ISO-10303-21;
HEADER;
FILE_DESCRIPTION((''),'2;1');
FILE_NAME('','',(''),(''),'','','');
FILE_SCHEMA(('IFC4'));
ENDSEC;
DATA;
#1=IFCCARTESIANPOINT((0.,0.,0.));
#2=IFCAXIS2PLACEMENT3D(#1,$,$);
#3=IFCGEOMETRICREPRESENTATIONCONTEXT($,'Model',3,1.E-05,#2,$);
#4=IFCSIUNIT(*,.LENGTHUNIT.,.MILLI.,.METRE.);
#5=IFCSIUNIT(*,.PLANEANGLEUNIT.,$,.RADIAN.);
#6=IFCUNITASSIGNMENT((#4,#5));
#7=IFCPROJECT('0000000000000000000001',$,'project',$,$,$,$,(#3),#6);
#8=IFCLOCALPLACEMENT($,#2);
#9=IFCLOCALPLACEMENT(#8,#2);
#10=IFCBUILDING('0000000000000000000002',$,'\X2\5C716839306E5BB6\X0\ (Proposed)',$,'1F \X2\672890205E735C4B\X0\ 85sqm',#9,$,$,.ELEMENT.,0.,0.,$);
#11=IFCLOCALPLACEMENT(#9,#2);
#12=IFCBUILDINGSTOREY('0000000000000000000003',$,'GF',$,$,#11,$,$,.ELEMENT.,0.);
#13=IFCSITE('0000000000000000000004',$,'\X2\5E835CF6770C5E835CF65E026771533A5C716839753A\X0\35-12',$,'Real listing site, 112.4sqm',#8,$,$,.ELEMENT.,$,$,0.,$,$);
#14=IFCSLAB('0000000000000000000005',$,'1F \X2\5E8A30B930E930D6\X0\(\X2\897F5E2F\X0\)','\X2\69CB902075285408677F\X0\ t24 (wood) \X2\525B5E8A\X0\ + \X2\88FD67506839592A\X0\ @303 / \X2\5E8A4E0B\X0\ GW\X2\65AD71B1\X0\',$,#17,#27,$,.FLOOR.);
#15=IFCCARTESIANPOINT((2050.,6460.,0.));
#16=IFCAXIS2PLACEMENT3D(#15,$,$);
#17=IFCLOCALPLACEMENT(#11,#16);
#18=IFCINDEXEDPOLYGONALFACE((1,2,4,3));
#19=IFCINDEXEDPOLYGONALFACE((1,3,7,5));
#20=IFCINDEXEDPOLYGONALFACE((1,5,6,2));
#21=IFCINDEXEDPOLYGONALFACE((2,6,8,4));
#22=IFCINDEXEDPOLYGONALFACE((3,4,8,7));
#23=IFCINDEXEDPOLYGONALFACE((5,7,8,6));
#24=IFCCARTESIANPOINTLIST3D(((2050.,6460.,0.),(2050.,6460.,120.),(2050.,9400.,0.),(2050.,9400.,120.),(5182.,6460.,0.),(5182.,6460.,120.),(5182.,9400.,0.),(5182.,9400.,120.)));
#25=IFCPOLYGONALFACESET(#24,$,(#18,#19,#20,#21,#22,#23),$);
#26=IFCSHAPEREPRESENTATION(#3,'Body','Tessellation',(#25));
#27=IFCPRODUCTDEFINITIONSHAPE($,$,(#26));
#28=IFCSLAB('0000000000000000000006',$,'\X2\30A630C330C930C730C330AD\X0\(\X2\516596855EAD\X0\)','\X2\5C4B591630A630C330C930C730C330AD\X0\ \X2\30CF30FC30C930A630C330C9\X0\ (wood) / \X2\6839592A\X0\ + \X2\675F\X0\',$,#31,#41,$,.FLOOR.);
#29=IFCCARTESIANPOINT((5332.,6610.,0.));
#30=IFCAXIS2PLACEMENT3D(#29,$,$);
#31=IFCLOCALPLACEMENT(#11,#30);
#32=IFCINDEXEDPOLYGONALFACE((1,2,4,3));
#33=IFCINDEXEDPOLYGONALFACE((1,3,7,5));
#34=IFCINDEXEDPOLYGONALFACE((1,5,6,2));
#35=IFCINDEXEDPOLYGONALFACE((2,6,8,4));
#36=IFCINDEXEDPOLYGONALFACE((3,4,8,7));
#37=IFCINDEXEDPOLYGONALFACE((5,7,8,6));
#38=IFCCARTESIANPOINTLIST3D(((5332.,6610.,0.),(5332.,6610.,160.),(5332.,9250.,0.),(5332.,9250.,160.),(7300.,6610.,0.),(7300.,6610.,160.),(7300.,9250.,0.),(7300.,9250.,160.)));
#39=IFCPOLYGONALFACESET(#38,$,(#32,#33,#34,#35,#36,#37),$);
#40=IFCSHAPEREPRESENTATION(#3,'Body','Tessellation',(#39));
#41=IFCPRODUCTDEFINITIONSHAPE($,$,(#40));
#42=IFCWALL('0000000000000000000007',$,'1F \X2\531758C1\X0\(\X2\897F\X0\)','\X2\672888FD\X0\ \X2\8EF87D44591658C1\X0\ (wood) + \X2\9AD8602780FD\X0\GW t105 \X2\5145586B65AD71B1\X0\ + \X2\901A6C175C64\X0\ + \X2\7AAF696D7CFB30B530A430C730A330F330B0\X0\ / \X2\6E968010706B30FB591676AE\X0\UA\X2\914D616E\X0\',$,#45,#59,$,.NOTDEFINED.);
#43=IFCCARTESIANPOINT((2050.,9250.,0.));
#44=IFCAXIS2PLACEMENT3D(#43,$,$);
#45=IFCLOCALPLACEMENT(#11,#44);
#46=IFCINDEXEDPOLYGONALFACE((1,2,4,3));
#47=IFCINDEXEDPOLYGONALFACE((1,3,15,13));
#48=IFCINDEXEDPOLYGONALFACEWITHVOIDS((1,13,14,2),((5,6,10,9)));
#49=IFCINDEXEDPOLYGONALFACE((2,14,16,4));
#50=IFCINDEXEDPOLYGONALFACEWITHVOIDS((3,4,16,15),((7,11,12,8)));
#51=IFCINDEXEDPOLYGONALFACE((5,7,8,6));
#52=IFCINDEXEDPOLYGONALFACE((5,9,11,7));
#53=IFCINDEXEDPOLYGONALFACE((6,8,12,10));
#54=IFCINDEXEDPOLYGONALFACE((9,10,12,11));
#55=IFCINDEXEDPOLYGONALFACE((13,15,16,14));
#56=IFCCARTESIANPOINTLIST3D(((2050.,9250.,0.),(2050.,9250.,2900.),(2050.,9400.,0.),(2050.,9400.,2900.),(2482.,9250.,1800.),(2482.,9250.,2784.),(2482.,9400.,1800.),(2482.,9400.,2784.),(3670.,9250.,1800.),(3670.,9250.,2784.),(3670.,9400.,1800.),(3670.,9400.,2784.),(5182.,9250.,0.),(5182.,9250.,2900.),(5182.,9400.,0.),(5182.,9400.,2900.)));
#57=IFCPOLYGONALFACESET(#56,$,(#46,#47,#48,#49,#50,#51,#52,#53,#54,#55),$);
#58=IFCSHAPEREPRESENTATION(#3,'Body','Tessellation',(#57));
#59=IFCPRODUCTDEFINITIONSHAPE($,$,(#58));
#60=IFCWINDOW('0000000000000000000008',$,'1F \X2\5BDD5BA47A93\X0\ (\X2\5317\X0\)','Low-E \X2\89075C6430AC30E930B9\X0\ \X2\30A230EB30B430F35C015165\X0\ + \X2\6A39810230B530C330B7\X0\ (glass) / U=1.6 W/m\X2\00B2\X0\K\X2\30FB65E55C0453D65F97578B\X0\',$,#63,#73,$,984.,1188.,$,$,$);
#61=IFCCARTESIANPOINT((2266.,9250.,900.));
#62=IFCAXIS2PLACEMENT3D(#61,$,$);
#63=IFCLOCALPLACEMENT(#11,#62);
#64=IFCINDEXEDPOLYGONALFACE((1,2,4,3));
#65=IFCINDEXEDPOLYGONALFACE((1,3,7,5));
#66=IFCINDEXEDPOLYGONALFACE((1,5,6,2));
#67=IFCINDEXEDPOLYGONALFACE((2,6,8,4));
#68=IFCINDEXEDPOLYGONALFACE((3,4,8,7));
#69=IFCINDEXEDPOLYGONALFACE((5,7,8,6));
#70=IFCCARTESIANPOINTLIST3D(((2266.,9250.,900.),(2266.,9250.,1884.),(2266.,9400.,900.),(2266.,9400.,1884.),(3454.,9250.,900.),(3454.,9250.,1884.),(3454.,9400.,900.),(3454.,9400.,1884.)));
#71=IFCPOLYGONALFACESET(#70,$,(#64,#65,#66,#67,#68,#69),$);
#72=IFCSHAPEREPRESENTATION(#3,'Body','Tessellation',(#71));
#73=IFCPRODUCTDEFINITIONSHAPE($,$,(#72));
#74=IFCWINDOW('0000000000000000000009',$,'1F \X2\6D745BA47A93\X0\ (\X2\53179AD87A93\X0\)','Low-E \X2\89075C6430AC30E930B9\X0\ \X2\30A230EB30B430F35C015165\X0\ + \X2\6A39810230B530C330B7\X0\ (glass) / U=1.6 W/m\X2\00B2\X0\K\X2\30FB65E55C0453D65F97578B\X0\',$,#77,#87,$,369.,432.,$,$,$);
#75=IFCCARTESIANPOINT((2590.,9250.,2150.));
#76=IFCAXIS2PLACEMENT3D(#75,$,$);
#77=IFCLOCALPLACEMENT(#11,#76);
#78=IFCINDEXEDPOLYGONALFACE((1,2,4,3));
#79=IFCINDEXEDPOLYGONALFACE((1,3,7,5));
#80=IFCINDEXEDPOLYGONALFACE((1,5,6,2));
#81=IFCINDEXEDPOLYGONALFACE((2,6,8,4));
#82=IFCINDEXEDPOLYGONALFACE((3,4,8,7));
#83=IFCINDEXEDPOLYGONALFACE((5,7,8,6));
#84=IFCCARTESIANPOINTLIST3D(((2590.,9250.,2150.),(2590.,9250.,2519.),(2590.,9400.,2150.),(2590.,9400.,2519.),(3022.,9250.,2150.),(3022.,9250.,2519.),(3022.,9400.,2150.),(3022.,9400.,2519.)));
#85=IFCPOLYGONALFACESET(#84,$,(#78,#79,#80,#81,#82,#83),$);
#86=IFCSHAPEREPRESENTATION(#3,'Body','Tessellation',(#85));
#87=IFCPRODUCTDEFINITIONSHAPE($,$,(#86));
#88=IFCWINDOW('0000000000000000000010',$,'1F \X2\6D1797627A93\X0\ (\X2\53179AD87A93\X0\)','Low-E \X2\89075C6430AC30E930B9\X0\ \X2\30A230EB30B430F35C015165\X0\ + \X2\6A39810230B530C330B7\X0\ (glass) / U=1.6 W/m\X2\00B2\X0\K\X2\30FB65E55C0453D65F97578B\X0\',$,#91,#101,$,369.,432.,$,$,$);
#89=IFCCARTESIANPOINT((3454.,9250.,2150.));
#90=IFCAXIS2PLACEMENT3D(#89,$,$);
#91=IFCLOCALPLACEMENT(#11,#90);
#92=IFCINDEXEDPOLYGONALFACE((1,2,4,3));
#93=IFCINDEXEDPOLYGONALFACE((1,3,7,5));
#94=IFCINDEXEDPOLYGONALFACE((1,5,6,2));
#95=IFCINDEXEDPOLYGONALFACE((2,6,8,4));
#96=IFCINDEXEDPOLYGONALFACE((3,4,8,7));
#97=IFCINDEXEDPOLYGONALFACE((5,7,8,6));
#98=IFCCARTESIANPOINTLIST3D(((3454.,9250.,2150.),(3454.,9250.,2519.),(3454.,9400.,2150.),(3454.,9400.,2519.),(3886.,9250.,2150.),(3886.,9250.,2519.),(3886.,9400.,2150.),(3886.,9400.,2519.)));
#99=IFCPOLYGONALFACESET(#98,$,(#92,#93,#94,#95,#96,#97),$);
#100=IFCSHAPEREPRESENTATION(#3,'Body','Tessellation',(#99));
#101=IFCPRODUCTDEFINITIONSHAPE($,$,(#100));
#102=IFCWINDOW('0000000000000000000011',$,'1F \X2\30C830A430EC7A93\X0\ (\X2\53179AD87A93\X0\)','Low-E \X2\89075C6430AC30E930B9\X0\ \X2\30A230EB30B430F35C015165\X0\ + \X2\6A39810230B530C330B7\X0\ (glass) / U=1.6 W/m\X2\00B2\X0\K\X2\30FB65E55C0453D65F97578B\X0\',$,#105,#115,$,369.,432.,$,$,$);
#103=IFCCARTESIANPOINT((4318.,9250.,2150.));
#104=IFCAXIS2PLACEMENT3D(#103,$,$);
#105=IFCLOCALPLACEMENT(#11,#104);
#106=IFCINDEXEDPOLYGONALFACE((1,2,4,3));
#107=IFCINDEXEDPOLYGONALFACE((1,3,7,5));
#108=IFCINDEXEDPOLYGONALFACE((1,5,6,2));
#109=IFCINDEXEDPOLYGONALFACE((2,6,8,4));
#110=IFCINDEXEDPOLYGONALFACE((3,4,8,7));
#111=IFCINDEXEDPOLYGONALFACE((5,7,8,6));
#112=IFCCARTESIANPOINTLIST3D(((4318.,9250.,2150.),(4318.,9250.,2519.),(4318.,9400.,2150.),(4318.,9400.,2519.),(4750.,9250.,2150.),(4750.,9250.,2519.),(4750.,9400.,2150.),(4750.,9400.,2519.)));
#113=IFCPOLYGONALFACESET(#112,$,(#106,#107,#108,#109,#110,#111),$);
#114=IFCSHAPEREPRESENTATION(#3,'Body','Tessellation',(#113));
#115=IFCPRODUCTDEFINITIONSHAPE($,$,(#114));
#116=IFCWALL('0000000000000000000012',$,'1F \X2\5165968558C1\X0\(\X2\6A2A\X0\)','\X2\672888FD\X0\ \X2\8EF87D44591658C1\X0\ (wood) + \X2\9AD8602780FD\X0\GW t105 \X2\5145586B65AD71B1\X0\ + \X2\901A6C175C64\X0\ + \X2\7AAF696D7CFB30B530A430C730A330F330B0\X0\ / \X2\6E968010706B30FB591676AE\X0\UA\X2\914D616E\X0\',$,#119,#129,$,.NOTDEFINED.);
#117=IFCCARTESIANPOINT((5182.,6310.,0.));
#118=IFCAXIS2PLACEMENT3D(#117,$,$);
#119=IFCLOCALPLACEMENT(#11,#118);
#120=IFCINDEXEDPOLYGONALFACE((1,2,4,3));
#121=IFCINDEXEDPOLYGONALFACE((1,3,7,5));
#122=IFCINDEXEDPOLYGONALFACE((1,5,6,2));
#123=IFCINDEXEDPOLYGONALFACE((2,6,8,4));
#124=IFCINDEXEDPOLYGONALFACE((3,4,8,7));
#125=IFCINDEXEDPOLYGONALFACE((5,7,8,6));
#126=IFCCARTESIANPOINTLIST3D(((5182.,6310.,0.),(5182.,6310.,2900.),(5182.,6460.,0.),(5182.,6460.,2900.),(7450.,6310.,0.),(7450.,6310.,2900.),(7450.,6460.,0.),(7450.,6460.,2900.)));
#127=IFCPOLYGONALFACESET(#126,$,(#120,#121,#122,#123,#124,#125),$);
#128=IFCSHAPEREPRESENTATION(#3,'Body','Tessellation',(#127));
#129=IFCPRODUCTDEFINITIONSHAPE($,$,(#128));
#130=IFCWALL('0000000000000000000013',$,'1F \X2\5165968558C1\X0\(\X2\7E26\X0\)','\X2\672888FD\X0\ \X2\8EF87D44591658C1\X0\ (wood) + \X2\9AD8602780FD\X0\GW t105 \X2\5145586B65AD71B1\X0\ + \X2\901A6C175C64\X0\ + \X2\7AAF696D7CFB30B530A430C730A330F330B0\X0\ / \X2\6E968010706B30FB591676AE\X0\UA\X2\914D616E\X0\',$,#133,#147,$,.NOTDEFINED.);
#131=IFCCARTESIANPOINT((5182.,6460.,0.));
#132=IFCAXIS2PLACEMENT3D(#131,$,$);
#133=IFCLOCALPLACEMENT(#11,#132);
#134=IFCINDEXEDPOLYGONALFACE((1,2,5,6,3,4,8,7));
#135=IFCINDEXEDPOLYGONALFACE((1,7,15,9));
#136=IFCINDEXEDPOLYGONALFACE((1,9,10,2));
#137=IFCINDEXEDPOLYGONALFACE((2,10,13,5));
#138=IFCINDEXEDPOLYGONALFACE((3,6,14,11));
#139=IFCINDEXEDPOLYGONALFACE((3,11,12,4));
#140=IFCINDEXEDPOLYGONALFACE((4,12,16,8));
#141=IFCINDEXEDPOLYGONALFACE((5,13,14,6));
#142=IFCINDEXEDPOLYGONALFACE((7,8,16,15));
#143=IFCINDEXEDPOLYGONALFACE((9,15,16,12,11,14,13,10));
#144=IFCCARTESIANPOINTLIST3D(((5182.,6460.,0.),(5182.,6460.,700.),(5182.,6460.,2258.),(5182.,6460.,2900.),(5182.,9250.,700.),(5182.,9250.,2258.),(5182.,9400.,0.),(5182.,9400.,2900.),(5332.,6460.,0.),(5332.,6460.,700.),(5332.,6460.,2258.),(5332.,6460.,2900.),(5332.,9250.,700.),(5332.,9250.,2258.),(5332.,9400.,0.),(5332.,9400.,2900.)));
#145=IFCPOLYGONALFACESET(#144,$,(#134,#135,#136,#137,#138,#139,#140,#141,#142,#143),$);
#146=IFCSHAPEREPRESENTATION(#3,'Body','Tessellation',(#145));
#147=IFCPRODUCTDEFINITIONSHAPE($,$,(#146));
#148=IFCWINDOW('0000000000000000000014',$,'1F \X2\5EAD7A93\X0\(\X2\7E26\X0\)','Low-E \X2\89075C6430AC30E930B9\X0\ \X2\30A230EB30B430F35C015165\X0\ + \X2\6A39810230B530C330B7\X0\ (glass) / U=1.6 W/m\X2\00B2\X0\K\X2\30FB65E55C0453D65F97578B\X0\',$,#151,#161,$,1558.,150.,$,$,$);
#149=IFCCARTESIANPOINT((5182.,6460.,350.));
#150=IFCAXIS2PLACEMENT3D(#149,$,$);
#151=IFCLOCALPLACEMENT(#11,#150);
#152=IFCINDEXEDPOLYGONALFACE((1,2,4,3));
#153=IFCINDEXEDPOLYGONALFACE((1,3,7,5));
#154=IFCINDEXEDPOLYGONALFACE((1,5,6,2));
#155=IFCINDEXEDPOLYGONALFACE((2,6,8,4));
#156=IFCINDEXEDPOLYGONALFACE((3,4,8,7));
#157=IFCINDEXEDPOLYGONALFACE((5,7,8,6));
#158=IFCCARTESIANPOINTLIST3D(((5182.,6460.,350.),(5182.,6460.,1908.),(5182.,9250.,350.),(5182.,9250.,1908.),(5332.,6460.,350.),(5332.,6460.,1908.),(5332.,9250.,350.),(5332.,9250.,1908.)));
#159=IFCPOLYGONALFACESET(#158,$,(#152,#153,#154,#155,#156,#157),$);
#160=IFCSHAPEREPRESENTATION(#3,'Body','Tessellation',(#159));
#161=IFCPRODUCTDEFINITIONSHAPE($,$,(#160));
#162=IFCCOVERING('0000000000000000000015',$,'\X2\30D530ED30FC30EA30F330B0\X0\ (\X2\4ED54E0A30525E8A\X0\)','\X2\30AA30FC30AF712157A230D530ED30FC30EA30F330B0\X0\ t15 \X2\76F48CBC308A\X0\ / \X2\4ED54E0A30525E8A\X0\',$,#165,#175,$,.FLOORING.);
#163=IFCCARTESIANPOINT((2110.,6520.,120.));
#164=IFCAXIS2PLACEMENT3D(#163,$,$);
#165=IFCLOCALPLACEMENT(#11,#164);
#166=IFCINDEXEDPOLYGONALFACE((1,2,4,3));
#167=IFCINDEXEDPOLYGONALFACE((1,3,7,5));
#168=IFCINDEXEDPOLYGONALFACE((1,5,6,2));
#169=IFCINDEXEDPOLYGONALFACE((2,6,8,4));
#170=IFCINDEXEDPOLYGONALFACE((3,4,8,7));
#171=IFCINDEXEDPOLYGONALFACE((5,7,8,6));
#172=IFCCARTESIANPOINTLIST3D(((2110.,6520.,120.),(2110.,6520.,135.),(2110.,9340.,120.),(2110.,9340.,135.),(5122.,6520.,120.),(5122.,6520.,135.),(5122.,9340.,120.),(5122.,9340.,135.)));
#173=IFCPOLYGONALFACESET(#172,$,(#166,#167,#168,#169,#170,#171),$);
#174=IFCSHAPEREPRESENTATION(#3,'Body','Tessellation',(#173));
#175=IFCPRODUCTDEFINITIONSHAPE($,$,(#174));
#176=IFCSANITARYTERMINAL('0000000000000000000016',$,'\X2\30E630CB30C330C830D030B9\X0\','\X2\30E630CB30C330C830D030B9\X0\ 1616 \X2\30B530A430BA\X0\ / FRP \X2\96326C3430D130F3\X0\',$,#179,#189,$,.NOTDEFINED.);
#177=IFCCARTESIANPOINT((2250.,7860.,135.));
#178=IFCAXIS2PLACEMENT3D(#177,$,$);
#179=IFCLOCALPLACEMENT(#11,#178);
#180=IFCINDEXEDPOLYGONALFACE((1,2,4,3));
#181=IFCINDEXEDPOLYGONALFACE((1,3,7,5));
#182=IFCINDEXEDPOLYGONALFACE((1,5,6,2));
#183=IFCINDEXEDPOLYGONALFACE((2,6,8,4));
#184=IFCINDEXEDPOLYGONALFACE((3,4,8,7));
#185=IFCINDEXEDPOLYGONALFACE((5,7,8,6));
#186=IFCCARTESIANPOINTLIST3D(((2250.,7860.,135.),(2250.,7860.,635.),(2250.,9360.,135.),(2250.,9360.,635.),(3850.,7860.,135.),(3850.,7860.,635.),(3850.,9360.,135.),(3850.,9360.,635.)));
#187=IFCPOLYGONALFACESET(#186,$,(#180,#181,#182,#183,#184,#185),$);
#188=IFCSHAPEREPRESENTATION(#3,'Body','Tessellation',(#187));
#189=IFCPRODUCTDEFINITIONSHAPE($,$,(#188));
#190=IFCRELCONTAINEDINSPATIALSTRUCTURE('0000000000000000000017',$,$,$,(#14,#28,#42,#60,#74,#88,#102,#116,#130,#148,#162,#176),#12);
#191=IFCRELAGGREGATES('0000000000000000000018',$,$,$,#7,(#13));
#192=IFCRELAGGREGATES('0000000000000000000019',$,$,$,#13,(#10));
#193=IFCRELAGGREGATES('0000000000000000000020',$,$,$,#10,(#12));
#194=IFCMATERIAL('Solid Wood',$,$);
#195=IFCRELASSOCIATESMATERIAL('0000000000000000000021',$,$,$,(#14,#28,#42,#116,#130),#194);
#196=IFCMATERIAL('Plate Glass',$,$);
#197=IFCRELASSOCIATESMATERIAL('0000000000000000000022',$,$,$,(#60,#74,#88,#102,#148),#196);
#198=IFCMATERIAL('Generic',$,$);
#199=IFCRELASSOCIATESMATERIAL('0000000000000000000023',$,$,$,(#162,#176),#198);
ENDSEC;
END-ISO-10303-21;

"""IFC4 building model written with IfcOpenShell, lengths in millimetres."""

from ifc_helpers import new_model, si_unit, frame, frame_2d, origin, place, context, project, spatial, rectangle, extrude, material, element, fill, save


model = new_model("IFC4")

# Units and contexts
model_context = context("Model", 3, precision=1e-05, world=origin())
ifc_project = project(units=[si_unit("LENGTHUNIT", "METRE", prefix="MILLI"), si_unit("PLANEANGLEUNIT", "RADIAN")], contexts=[model_context])

# Site, building, storey
site_placement = place(None, origin())
site = spatial("IfcSite", under=ifc_project, at=site_placement, Name="広島県広島市東区山根町35-12", ObjectType="Real listing site, 112.4sqm", CompositionType="ELEMENT", RefElevation=0.0)
building_placement = place(site_placement, origin())
building = spatial("IfcBuilding", under=site, at=building_placement, Name="山根の家 (Proposed)", ObjectType="1F 木造平屋 85sqm", CompositionType="ELEMENT", ElevationOfRefHeight=0.0, ElevationOfTerrain=0.0)
storey_placement = place(building_placement, origin())
storey = spatial("IfcBuildingStorey", under=building, at=storey_placement, Name="GF", CompositionType="ELEMENT", Elevation=0.0)

# Slabs
ifc_material_1 = material(Name="Solid Wood")
slab_1_placement = place(storey_placement, frame((2050.0, 6460.0, 0.0)))
element("IfcSlab", 1, at=slab_1_placement, inside=storey, material=ifc_material_1, Name="1F 床スラブ(西帯)", Description="構造用合板 t24 (wood) 剛床 + 製材根太 @303 / 床下 GW断熱", PredefinedType="FLOOR", context=model_context, shape_type="SweptSolid", body=[
    extrude(rectangle(XDim=3132.0, YDim=2940.0, at=frame_2d((1566.0, 1470.0))), frame((2050.0, 6460.0, 0.0)), (0.0, 0.0, 1.0), 120.0),
])
slab_2_placement = place(storey_placement, frame((5332.0, 6610.0, 0.0)))
element("IfcSlab", 2, at=slab_2_placement, inside=storey, material=ifc_material_1, Name="ウッドデッキ(入隅庭)", Description="屋外ウッドデッキ ハードウッド (wood) / 根太 + 束", PredefinedType="FLOOR", context=model_context, shape_type="SweptSolid", body=[
    extrude(rectangle(XDim=1968.0, YDim=2640.0, at=frame_2d((984.0, 1320.0))), frame((5332.0, 6610.0, 0.0)), (0.0, 0.0, 1.0), 160.0),
])

# Wall, openings, windows
wall_1_placement = place(storey_placement, frame((2050.0, 9250.0, 0.0)))
wall_1 = element("IfcWall", 3, at=wall_1_placement, inside=storey, material=ifc_material_1, Name="1F 北壁(西)", Description="木製 軸組外壁 (wood) + 高性能GW t105 充填断熱 + 通気層 + 窯業系サイディング / 準耐火・外皮UA配慮", PredefinedType="NOTDEFINED", context=model_context, shape_type="SweptSolid", body=[
    extrude(rectangle(XDim=3132.0, YDim=150.0, at=frame_2d((1566.0, 75.0))), frame((2050.0, 9250.0, 0.0)), (0.0, 0.0, 1.0), 2900.0),
])
opening_1_placement = place(storey_placement, frame((2266.0, 9250.0, 900.0)))
opening_1 = element("IfcOpeningElement", 4, at=opening_1_placement, cuts=wall_1, PredefinedType="NOTDEFINED", context=model_context, shape_type="SweptSolid", body=[
    extrude(rectangle(XDim=1188.0, YDim=150.0, at=frame_2d((594.0, 75.0))), frame((2266.0, 9250.0, 900.0)), (0.0, 0.0, 1.0), 984.0),
])
opening_2_placement = place(storey_placement, frame((2590.0, 9250.0, 2150.0)))
opening_2 = element("IfcOpeningElement", 5, at=opening_2_placement, cuts=wall_1, PredefinedType="NOTDEFINED", context=model_context, shape_type="SweptSolid", body=[
    extrude(rectangle(XDim=432.0, YDim=150.0, at=frame_2d((216.0, 75.0))), frame((2590.0, 9250.0, 2150.0)), (0.0, 0.0, 1.0), 369.0),
])
opening_3_placement = place(storey_placement, frame((3454.0, 9250.0, 2150.0)))
opening_3 = element("IfcOpeningElement", 6, at=opening_3_placement, cuts=wall_1, PredefinedType="NOTDEFINED", context=model_context, shape_type="SweptSolid", body=[
    extrude(rectangle(XDim=432.0, YDim=150.0, at=frame_2d((216.0, 75.0))), frame((3454.0, 9250.0, 2150.0)), (0.0, 0.0, 1.0), 369.0),
])
opening_4_placement = place(storey_placement, frame((4318.0, 9250.0, 2150.0)))
opening_4 = element("IfcOpeningElement", 7, at=opening_4_placement, cuts=wall_1, PredefinedType="NOTDEFINED", context=model_context, shape_type="SweptSolid", body=[
    extrude(rectangle(XDim=432.0, YDim=150.0, at=frame_2d((216.0, 75.0))), frame((4318.0, 9250.0, 2150.0)), (0.0, 0.0, 1.0), 369.0),
])
ifc_material_2 = material(Name="Plate Glass")
window_1_placement = place(storey_placement, frame((2266.0, 9250.0, 900.0)))
window_1 = element("IfcWindow", 8, at=window_1_placement, inside=storey, material=ifc_material_2, Name="1F 寝室窓 (北)", Description="Low-E 複層ガラス アルゴン封入 + 樹脂サッシ (glass) / U=1.6 W/m²K・日射取得型", OverallHeight=984.0, OverallWidth=1188.0, context=model_context, shape_type="SweptSolid", body=[
    extrude(rectangle(XDim=1188.0, YDim=150.0, at=frame_2d((594.0, 75.0))), frame((2266.0, 9250.0, 900.0)), (0.0, 0.0, 1.0), 984.0),
])
fill(opening_1, window_1)
window_2_placement = place(storey_placement, frame((2590.0, 9250.0, 2150.0)))
window_2 = element("IfcWindow", 9, at=window_2_placement, inside=storey, material=ifc_material_2, Name="1F 浴室窓 (北高窓)", Description="Low-E 複層ガラス アルゴン封入 + 樹脂サッシ (glass) / U=1.6 W/m²K・日射取得型", OverallHeight=369.0, OverallWidth=432.0, context=model_context, shape_type="SweptSolid", body=[
    extrude(rectangle(XDim=432.0, YDim=150.0, at=frame_2d((216.0, 75.0))), frame((2590.0, 9250.0, 2150.0)), (0.0, 0.0, 1.0), 369.0),
])
fill(opening_2, window_2)
window_3_placement = place(storey_placement, frame((3454.0, 9250.0, 2150.0)))
window_3 = element("IfcWindow", 10, at=window_3_placement, inside=storey, material=ifc_material_2, Name="1F 洗面窓 (北高窓)", Description="Low-E 複層ガラス アルゴン封入 + 樹脂サッシ (glass) / U=1.6 W/m²K・日射取得型", OverallHeight=369.0, OverallWidth=432.0, context=model_context, shape_type="SweptSolid", body=[
    extrude(rectangle(XDim=432.0, YDim=150.0, at=frame_2d((216.0, 75.0))), frame((3454.0, 9250.0, 2150.0)), (0.0, 0.0, 1.0), 369.0),
])
fill(opening_3, window_3)
window_4_placement = place(storey_placement, frame((4318.0, 9250.0, 2150.0)))
window_4 = element("IfcWindow", 11, at=window_4_placement, inside=storey, material=ifc_material_2, Name="1F トイレ窓 (北高窓)", Description="Low-E 複層ガラス アルゴン封入 + 樹脂サッシ (glass) / U=1.6 W/m²K・日射取得型", OverallHeight=369.0, OverallWidth=432.0, context=model_context, shape_type="SweptSolid", body=[
    extrude(rectangle(XDim=432.0, YDim=150.0, at=frame_2d((216.0, 75.0))), frame((4318.0, 9250.0, 2150.0)), (0.0, 0.0, 1.0), 369.0),
])
fill(opening_4, window_4)

# Wall
wall_2_placement = place(storey_placement, frame((5182.0, 6310.0, 0.0)))
element("IfcWall", 12, at=wall_2_placement, inside=storey, material=ifc_material_1, Name="1F 入隅壁(横)", Description="木製 軸組外壁 (wood) + 高性能GW t105 充填断熱 + 通気層 + 窯業系サイディング / 準耐火・外皮UA配慮", PredefinedType="NOTDEFINED", context=model_context, shape_type="SweptSolid", body=[
    extrude(rectangle(XDim=2268.0, YDim=150.0, at=frame_2d((1134.0, 75.0))), frame((5182.0, 6310.0, 0.0)), (0.0, 0.0, 1.0), 2900.0),
])

# Wall, opening, window
wall_3_placement = place(storey_placement, frame((5182.0, 6460.0, 0.0)))
wall_3 = element("IfcWall", 13, at=wall_3_placement, inside=storey, material=ifc_material_1, Name="1F 入隅壁(縦)", Description="木製 軸組外壁 (wood) + 高性能GW t105 充填断熱 + 通気層 + 窯業系サイディング / 準耐火・外皮UA配慮", PredefinedType="NOTDEFINED", context=model_context, shape_type="SweptSolid", body=[
    extrude(rectangle(XDim=150.0, YDim=2940.0, at=frame_2d((75.0, 1470.0))), frame((5182.0, 6460.0, 0.0)), (0.0, 0.0, 1.0), 2900.0),
])
opening_5_placement = place(storey_placement, frame((5182.0, 6460.0, 350.0)))
opening_5 = element("IfcOpeningElement", 14, at=opening_5_placement, cuts=wall_3, PredefinedType="NOTDEFINED", context=model_context, shape_type="SweptSolid", body=[
    extrude(rectangle(XDim=150.0, YDim=2790.0, at=frame_2d((75.0, 1395.0))), frame((5182.0, 6460.0, 350.0)), (0.0, 0.0, 1.0), 1558.0),
])
window_5_placement = place(storey_placement, frame((5182.0, 6460.0, 350.0)))
window_5 = element("IfcWindow", 15, at=window_5_placement, inside=storey, material=ifc_material_2, Name="1F 庭窓(縦)", Description="Low-E 複層ガラス アルゴン封入 + 樹脂サッシ (glass) / U=1.6 W/m²K・日射取得型", OverallHeight=1558.0, OverallWidth=150.0, context=model_context, shape_type="SweptSolid", body=[
    extrude(rectangle(XDim=150.0, YDim=2790.0, at=frame_2d((75.0, 1395.0))), frame((5182.0, 6460.0, 350.0)), (0.0, 0.0, 1.0), 1558.0),
])
fill(opening_5, window_5)

# Covering
ifc_material_3 = material(Name="Generic")
covering_placement = place(storey_placement, frame((2110.0, 6520.0, 120.0)))
element("IfcCovering", 16, at=covering_placement, inside=storey, material=ifc_material_3, Name="フローリング (仕上げ床)", Description="オーク無垢フローリング t15 直貼り / 仕上げ床", PredefinedType="FLOORING", context=model_context, shape_type="SweptSolid", body=[
    extrude(rectangle(XDim=3012.0, YDim=2820.0, at=frame_2d((1506.0, 1410.0))), frame((2110.0, 6520.0, 120.0)), (0.0, 0.0, 1.0), 15.0),
])

# Sanitary terminal
sanitary_terminal_1_placement = place(storey_placement, frame((2250.0, 7860.0, 135.0)))
element("IfcSanitaryTerminal", 17, at=sanitary_terminal_1_placement, inside=storey, material=ifc_material_3, Name="ユニットバス", Description="ユニットバス 1616 サイズ / FRP 防水パン", PredefinedType="NOTDEFINED", context=model_context, shape_type="SweptSolid", body=[
    extrude(rectangle(XDim=1600.0, YDim=1500.0, at=frame_2d((800.0, 750.0))), frame((2250.0, 7860.0, 135.0)), (0.0, 0.0, 1.0), 500.0),
])

save(model, "model.ifc")
